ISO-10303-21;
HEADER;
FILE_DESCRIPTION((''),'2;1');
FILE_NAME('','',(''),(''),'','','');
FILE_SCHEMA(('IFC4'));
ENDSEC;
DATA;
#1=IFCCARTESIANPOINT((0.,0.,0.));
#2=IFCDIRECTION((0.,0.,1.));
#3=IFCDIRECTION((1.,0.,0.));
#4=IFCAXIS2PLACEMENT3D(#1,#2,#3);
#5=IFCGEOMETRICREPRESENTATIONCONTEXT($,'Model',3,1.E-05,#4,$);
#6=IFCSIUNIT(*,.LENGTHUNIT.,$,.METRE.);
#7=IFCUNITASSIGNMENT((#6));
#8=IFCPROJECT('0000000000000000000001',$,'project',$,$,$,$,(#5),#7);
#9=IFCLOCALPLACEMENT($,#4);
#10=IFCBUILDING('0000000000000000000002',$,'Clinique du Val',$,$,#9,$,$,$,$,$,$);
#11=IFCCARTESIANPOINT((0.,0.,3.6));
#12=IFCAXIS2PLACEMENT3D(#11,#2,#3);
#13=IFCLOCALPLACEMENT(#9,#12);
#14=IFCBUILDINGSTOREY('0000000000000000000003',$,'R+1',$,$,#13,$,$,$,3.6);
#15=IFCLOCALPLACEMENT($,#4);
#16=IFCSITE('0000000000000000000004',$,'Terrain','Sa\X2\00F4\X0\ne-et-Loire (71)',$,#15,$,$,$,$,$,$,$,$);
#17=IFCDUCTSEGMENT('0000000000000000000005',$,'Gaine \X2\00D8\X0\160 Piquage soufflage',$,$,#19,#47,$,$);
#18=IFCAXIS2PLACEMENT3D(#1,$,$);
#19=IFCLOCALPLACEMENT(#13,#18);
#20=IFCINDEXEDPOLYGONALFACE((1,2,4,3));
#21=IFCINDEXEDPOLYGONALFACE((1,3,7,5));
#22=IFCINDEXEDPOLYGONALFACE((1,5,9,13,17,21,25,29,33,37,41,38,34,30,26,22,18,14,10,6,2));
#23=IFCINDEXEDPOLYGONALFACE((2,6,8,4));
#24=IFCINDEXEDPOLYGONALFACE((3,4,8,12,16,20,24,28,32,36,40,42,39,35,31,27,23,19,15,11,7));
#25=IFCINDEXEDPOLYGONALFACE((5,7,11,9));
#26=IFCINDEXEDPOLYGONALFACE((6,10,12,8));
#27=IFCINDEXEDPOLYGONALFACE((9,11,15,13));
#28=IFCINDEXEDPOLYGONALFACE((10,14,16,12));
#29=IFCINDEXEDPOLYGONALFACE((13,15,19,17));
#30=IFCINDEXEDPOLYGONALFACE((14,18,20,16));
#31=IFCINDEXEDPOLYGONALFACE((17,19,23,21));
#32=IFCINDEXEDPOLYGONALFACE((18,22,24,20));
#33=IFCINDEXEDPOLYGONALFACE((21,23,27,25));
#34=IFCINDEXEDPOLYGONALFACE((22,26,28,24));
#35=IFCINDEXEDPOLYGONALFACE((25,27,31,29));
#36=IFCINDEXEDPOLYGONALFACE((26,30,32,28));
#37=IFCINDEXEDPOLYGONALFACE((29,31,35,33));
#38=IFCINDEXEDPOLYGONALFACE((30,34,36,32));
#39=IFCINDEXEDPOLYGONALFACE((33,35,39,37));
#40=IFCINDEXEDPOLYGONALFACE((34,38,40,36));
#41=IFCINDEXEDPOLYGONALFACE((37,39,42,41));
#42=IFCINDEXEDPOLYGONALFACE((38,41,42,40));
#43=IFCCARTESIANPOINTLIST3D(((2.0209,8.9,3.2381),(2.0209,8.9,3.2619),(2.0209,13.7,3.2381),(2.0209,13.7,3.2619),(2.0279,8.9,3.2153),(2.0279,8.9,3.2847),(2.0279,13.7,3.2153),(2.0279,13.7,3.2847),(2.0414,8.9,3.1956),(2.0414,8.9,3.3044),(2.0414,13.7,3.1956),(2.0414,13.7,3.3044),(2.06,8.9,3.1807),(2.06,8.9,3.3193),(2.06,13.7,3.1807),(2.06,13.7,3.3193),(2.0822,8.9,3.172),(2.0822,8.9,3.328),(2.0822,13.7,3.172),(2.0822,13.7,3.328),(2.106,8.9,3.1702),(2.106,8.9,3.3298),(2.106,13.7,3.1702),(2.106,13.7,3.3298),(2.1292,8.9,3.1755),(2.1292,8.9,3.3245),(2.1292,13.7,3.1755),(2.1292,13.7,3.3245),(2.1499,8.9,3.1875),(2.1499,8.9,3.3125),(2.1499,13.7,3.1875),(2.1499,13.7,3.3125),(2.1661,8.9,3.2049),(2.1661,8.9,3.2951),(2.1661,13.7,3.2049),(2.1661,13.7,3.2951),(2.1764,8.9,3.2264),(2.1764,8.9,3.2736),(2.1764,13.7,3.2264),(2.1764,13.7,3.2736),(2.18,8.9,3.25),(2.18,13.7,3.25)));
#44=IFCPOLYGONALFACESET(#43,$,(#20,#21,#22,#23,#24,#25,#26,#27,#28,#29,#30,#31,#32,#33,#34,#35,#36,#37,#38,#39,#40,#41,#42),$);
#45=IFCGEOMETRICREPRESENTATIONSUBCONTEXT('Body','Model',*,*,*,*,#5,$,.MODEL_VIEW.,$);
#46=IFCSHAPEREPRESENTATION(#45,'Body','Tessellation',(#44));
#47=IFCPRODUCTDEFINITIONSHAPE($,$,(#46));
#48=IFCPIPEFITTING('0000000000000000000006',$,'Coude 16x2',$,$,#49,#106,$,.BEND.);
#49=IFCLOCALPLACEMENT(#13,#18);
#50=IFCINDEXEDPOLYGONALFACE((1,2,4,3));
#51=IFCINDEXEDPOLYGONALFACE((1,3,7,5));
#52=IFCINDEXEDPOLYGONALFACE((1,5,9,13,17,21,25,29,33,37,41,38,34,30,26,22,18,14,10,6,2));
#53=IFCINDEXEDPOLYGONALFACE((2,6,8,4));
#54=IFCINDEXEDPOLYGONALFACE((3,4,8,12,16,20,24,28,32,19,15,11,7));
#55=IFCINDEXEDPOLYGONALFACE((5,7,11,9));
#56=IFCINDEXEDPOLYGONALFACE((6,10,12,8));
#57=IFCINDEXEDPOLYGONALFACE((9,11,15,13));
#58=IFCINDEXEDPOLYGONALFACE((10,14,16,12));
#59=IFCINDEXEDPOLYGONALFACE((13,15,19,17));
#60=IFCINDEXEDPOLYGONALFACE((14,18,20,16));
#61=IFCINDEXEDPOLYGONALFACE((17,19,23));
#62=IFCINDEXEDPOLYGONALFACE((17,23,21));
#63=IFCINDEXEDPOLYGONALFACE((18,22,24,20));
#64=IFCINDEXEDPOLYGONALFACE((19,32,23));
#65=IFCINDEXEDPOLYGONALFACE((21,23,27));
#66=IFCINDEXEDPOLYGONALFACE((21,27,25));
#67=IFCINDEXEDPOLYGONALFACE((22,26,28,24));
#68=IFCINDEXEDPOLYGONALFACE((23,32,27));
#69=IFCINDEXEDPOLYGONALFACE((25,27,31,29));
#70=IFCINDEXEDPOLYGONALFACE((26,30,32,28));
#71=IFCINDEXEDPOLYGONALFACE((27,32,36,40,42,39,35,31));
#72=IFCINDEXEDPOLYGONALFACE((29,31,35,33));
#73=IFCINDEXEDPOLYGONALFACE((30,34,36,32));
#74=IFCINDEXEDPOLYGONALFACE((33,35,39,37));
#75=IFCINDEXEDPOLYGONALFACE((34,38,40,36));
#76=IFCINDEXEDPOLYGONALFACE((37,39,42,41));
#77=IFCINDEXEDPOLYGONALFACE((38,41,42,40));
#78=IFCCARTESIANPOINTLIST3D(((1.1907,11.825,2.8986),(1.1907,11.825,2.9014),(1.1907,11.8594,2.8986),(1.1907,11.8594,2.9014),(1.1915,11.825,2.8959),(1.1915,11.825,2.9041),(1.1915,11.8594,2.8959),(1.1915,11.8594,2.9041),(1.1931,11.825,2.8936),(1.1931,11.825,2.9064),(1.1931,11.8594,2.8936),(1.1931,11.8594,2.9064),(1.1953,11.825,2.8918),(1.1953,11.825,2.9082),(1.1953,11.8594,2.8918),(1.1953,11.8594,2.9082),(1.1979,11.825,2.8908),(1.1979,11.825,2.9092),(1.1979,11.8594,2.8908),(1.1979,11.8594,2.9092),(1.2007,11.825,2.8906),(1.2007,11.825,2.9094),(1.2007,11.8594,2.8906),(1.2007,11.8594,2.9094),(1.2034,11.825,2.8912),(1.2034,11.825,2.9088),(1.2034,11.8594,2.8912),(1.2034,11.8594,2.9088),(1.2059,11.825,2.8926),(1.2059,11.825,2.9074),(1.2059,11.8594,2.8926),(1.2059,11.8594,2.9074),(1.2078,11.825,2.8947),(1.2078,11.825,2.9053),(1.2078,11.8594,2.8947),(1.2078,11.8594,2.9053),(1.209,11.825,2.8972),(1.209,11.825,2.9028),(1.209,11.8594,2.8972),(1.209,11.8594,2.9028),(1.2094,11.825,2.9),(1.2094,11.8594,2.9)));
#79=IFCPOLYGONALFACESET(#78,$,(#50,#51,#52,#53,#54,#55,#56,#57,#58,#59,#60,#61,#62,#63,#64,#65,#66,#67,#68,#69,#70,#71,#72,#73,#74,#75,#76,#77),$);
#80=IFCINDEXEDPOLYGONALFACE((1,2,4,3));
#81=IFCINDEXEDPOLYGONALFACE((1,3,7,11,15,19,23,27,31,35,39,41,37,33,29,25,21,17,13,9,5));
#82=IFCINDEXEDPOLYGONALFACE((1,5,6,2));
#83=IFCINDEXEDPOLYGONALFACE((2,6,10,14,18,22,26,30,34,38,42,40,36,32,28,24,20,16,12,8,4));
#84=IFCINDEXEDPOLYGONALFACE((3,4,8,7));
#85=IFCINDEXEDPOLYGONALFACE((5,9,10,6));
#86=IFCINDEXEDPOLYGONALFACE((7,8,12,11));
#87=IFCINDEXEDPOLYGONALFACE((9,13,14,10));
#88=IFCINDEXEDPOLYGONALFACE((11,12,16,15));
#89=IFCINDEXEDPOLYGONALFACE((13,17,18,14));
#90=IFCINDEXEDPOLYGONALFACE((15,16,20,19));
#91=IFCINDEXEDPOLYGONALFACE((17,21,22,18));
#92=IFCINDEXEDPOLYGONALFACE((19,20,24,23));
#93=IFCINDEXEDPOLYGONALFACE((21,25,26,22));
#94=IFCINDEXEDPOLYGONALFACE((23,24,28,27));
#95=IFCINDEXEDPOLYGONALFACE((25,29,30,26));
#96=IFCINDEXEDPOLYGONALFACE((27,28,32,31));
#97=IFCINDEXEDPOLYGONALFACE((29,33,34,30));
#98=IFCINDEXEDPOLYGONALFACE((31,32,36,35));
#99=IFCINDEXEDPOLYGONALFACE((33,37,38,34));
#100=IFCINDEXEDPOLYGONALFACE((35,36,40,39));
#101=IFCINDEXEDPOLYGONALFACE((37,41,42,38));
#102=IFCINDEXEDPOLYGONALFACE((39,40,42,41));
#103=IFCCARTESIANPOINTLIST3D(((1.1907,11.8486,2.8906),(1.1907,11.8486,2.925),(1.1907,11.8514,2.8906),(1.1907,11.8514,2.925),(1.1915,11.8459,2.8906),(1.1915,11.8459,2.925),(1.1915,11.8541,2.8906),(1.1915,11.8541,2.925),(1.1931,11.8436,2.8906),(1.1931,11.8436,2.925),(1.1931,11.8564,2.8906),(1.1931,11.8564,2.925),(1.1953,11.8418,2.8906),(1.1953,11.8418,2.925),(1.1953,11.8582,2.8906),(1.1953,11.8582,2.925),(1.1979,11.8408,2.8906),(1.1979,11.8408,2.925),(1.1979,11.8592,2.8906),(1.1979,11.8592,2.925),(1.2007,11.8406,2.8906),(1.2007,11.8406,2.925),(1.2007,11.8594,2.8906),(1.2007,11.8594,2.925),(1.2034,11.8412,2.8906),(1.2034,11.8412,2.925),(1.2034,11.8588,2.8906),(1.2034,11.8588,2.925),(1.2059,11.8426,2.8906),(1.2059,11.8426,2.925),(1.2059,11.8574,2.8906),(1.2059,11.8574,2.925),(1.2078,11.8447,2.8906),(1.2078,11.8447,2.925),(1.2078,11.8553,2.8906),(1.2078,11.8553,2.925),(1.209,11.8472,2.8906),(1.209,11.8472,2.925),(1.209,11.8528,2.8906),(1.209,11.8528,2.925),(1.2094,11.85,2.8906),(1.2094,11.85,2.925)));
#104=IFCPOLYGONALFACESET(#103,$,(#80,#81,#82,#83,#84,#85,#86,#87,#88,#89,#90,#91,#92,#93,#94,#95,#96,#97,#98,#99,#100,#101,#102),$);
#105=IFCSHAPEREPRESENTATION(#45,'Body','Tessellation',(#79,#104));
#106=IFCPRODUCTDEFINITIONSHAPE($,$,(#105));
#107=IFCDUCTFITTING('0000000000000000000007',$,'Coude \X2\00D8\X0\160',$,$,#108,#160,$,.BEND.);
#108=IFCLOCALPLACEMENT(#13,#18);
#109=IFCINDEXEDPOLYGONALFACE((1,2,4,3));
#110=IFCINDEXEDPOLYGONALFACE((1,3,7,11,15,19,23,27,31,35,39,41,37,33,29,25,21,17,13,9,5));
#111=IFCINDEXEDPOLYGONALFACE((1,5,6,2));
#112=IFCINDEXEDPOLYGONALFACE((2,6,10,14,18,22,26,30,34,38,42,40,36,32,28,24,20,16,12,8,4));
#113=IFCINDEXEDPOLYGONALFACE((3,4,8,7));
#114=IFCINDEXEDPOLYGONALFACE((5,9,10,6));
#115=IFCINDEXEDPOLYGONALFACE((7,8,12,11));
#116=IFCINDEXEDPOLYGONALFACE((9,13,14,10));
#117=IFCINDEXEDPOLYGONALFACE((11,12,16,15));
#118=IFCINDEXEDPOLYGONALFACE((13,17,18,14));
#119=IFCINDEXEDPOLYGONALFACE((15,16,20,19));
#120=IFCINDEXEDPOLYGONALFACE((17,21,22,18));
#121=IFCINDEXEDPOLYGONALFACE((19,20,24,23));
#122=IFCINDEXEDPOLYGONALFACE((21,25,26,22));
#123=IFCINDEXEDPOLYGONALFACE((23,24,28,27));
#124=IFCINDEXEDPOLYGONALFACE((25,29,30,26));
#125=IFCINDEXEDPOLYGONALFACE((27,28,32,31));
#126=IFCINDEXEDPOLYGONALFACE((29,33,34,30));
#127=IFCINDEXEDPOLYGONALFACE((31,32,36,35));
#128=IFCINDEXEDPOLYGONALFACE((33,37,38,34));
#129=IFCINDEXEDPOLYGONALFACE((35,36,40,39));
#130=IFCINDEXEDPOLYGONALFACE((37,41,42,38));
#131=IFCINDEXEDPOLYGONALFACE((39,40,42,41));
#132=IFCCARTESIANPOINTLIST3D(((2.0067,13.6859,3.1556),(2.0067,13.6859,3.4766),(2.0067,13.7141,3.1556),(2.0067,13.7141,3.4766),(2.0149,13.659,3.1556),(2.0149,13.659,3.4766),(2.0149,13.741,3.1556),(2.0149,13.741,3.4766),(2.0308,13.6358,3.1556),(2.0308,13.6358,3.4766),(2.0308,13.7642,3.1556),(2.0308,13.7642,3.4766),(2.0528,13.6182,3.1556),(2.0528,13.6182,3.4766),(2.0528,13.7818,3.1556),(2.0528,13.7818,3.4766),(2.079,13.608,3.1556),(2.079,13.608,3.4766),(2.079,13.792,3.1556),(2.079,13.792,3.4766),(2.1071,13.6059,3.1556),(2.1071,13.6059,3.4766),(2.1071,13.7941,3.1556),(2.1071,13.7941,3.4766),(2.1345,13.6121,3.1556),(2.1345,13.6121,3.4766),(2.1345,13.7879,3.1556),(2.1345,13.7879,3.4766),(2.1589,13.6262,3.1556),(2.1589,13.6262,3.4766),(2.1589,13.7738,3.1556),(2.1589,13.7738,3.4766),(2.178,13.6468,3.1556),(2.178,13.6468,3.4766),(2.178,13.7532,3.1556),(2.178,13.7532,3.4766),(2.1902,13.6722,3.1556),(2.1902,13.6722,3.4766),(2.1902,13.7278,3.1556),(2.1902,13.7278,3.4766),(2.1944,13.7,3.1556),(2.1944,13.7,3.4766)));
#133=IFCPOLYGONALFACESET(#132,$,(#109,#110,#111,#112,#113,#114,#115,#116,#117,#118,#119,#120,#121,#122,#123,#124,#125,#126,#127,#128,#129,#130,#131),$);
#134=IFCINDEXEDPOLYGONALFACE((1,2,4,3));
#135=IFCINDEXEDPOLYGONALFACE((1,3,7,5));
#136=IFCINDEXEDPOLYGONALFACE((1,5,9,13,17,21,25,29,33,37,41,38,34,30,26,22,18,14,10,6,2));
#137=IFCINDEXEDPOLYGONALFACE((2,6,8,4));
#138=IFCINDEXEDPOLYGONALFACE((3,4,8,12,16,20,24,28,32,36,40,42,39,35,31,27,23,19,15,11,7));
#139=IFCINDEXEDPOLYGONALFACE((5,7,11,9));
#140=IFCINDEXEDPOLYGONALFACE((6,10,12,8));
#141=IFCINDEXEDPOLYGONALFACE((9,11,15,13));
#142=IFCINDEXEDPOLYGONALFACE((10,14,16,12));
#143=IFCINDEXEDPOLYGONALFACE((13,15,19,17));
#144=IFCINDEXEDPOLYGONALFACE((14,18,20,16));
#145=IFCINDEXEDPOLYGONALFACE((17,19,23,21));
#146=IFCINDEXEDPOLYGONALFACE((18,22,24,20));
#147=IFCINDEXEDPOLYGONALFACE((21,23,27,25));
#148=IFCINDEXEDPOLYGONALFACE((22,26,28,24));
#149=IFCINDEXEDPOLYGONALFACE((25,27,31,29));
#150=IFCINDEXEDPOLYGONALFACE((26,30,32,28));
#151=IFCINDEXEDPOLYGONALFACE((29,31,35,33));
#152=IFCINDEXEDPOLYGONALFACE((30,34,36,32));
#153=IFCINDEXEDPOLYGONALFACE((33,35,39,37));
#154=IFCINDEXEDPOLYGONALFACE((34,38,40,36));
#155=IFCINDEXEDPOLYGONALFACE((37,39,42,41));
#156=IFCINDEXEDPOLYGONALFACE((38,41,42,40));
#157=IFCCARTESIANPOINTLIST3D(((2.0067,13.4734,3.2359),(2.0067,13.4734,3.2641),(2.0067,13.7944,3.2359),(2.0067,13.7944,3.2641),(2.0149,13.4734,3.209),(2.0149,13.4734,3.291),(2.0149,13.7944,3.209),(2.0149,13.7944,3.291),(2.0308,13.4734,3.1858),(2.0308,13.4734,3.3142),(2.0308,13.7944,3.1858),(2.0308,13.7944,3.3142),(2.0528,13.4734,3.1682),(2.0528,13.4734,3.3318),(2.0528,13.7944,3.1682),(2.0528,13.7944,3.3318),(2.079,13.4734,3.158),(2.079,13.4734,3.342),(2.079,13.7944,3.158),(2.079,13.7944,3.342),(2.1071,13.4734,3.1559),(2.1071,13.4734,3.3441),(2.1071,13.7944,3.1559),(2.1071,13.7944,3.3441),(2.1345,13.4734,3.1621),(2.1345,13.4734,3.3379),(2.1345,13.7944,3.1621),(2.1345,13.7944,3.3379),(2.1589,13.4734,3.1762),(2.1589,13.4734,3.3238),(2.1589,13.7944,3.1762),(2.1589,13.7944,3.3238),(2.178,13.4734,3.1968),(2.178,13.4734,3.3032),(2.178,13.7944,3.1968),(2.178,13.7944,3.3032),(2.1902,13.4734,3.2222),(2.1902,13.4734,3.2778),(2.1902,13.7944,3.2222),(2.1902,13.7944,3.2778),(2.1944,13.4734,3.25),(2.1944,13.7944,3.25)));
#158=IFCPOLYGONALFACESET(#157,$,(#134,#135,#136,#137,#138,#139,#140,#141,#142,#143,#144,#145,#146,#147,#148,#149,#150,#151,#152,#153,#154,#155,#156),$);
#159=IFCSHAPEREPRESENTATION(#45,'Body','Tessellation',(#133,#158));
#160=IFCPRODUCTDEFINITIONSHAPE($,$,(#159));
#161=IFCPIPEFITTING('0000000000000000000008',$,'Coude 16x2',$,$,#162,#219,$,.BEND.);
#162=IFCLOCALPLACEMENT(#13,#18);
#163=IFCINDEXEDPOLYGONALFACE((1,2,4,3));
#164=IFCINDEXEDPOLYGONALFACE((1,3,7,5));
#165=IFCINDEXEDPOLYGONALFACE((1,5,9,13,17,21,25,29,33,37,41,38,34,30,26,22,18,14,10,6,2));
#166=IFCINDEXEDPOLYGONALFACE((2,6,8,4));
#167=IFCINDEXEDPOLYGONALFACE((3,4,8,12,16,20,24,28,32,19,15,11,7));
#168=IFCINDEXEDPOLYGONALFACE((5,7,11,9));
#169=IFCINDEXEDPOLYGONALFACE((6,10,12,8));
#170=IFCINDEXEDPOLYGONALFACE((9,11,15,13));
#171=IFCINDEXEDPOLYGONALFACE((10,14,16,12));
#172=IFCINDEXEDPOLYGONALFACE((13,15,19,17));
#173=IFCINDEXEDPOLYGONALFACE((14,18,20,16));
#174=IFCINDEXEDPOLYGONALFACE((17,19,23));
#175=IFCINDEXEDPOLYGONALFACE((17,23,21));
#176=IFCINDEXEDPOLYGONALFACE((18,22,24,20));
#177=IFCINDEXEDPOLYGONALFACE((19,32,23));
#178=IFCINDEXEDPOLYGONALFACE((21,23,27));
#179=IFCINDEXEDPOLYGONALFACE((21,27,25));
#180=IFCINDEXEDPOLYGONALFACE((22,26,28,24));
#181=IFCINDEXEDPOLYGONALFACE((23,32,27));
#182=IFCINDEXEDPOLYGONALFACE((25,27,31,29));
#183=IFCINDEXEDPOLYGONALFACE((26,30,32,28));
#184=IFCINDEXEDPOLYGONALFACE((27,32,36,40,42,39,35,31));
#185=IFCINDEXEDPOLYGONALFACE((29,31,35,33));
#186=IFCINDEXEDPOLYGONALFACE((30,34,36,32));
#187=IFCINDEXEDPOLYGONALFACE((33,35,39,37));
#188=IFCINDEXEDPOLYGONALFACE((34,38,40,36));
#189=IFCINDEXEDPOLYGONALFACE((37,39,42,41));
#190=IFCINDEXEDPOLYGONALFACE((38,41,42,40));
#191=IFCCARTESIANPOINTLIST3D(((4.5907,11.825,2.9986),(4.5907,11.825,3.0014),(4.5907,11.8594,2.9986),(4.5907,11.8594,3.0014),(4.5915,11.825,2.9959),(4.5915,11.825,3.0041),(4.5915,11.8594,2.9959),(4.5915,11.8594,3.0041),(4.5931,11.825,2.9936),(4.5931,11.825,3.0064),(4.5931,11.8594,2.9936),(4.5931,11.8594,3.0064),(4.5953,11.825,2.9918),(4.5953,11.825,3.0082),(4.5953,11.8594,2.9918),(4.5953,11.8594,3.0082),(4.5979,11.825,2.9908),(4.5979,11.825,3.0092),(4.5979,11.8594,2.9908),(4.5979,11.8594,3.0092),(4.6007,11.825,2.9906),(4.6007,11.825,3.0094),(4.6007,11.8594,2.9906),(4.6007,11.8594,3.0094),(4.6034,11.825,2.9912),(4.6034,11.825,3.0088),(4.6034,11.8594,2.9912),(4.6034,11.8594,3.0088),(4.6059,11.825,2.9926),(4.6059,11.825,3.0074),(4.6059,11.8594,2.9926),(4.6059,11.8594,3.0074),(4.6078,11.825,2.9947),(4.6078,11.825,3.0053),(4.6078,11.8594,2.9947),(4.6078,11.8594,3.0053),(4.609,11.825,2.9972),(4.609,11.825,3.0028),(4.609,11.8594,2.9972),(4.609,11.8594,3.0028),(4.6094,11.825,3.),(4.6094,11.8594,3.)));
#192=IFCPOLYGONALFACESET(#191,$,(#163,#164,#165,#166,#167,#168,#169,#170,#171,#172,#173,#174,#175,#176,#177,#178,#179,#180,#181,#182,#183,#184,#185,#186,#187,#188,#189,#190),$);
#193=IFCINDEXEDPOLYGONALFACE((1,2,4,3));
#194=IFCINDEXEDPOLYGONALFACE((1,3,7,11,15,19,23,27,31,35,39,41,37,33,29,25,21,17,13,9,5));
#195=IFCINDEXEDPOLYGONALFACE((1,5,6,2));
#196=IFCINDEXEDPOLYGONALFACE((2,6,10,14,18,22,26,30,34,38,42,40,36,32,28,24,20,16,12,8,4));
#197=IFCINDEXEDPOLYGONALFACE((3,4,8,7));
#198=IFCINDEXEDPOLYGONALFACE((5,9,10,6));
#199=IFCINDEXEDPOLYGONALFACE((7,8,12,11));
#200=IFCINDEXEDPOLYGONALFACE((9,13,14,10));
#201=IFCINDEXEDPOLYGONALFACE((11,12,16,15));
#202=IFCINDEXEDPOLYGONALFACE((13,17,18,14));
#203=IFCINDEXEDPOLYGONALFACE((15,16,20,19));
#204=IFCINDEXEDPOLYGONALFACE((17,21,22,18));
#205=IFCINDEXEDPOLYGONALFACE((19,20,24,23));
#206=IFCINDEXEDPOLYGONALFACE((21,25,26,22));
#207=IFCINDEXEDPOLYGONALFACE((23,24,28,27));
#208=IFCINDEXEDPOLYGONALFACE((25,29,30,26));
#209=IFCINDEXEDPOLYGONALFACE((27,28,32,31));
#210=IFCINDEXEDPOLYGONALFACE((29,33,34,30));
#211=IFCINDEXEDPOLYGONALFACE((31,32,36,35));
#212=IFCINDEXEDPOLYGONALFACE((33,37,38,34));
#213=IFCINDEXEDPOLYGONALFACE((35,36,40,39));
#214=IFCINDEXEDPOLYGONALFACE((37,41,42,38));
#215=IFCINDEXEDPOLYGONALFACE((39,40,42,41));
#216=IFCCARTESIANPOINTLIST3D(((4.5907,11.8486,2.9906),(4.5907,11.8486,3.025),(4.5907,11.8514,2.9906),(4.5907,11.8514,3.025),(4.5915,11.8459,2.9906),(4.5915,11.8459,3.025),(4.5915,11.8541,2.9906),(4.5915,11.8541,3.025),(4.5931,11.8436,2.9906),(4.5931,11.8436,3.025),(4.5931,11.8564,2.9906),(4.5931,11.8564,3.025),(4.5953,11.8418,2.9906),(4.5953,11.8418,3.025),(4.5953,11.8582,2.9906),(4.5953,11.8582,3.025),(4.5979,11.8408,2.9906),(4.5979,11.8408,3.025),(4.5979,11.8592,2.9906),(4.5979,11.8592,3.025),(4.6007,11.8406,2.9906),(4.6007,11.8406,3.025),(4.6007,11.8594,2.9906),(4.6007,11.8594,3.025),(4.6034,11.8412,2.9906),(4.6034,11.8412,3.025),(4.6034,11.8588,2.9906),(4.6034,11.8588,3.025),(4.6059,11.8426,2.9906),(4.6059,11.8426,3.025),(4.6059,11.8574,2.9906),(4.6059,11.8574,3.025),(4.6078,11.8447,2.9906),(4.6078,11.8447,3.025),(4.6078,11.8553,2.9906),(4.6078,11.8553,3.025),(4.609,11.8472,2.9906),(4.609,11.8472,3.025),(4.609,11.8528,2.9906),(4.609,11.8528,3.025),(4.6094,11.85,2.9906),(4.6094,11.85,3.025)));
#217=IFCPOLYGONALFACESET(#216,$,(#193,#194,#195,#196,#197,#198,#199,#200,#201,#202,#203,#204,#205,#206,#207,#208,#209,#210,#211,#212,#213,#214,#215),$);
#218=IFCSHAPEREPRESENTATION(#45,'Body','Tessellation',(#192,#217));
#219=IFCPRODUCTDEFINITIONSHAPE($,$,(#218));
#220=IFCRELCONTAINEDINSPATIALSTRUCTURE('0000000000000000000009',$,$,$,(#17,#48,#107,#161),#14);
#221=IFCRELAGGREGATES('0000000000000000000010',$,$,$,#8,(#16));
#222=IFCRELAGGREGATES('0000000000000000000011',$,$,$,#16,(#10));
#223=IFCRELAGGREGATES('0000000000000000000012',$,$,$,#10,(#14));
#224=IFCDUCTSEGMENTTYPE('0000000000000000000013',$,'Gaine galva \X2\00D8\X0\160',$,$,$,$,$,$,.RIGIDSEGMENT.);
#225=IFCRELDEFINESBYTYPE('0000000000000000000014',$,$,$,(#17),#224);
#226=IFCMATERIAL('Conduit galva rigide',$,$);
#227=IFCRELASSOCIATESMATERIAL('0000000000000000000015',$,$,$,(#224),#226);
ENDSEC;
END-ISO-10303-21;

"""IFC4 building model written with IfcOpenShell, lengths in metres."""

from ifc_helpers import new_model, si_unit, frame, origin_with_axes, place, context, subcontext, project, spatial, circle, extrude, material, type_object, element, save


model = new_model("IFC4")

# Units and contexts
model_context = context("Model", 3, precision=1e-05, world=origin_with_axes())
body_context = subcontext(model_context, "Body", "Model", "MODEL_VIEW")
ifc_project = project(units=[si_unit("LENGTHUNIT", "METRE")], contexts=[model_context])

# Site, building, storey
site_placement = place(None, origin_with_axes())
site = spatial("IfcSite", under=ifc_project, at=site_placement, Name="Terrain", Description="Saône-et-Loire (71)")
building_placement = place(None, origin_with_axes())
building = spatial("IfcBuilding", under=site, at=building_placement, Name="Clinique du Val")
storey_placement = place(building_placement, frame((0.0, 0.0, 3.6), z_axis=(0.0, 0.0, 1.0), x_axis=(1.0, 0.0, 0.0)))
storey = spatial("IfcBuildingStorey", under=building, at=storey_placement, Name="R+1", Elevation=3.6)

# Duct segment
ifc_material_1 = material(Name="Conduit galva rigide")
duct_segment_type = type_object("IfcDuctSegmentType", Name="Gaine galva Ø160", PredefinedType="RIGIDSEGMENT", material=ifc_material_1)
duct_segment_1_placement = place(storey_placement, frame((2.1, 13.7, 3.25), z_axis=(0.0, -1.0, 0.0), x_axis=(1.0, 0.0, 0.0)))
element("IfcDuctSegment", 1, at=duct_segment_1_placement, inside=storey, type_object=duct_segment_type, Name="Gaine Ø160 Piquage soufflage", context=body_context, shape_type="SweptSolid", body=[
    extrude(circle(Radius=0.08), origin_with_axes(), (0.0, 0.0, 1.0), 4.8),
])

# Pipe fitting
pipe_fitting_placement = place(storey_placement, frame((1.2, 11.85, 2.9), z_axis=(0.0, 0.0, 1.0), x_axis=(1.0, 0.0, 0.0)))
element("IfcPipeFitting", 2, at=pipe_fitting_placement, inside=storey, Name="Coude 16x2", PredefinedType="BEND", context=body_context, shape_type="SweptSolid", body=[
    extrude(circle(Radius=0.0094), frame((0.0, 0.0094, 0.0), z_axis=(0.0, -1.0, 0.0), x_axis=(1.0, 0.0, 0.0)), (0.0, 0.0, 1.0), 0.0344),
    extrude(circle(Radius=0.0094), frame((0.0, 0.0, -0.0094), z_axis=(0.0, 0.0, 1.0), x_axis=(1.0, 0.0, 0.0)), (0.0, 0.0, 1.0), 0.0344),
])

# Duct fitting
duct_fitting_placement = place(storey_placement, frame((2.1, 13.7, 3.25), z_axis=(0.0, 0.0, 1.0), x_axis=(1.0, 0.0, 0.0)))
element("IfcDuctFitting", 3, at=duct_fitting_placement, inside=storey, Name="Coude Ø160", PredefinedType="BEND", context=body_context, shape_type="SweptSolid", body=[
    extrude(circle(Radius=0.0944), frame((0.0, 0.0, -0.0944), z_axis=(0.0, 0.0, 1.0), x_axis=(1.0, 0.0, 0.0)), (0.0, 0.0, 1.0), 0.321),
    extrude(circle(Radius=0.0944), frame((0.0, 0.0944, 0.0), z_axis=(0.0, -1.0, 0.0), x_axis=(1.0, 0.0, 0.0)), (0.0, 0.0, 1.0), 0.321),
])

# Pipe fitting
for number, where, z_axis, x_axis, name in (
    (4, (4.6, 11.85, 3.0), (0.0, 0.0, 1.0), (1.0, 0.0, 0.0), "Coude 16x2"),
):
    element("IfcPipeFitting", number, at=place(storey_placement, frame(where, z_axis=z_axis, x_axis=x_axis)), inside=storey, Name=name, PredefinedType="BEND", context=body_context, shape_type="SweptSolid", body=[
        extrude(circle(Radius=0.0094), frame((0.0, 0.0094, 0.0), z_axis=(0.0, -1.0, 0.0), x_axis=(1.0, 0.0, 0.0)), (0.0, 0.0, 1.0), 0.0344),
        extrude(circle(Radius=0.0094), frame((0.0, 0.0, -0.0094), z_axis=(0.0, 0.0, 1.0), x_axis=(1.0, 0.0, 0.0)), (0.0, 0.0, 1.0), 0.0344),
    ])

save(model, "model.ifc")
